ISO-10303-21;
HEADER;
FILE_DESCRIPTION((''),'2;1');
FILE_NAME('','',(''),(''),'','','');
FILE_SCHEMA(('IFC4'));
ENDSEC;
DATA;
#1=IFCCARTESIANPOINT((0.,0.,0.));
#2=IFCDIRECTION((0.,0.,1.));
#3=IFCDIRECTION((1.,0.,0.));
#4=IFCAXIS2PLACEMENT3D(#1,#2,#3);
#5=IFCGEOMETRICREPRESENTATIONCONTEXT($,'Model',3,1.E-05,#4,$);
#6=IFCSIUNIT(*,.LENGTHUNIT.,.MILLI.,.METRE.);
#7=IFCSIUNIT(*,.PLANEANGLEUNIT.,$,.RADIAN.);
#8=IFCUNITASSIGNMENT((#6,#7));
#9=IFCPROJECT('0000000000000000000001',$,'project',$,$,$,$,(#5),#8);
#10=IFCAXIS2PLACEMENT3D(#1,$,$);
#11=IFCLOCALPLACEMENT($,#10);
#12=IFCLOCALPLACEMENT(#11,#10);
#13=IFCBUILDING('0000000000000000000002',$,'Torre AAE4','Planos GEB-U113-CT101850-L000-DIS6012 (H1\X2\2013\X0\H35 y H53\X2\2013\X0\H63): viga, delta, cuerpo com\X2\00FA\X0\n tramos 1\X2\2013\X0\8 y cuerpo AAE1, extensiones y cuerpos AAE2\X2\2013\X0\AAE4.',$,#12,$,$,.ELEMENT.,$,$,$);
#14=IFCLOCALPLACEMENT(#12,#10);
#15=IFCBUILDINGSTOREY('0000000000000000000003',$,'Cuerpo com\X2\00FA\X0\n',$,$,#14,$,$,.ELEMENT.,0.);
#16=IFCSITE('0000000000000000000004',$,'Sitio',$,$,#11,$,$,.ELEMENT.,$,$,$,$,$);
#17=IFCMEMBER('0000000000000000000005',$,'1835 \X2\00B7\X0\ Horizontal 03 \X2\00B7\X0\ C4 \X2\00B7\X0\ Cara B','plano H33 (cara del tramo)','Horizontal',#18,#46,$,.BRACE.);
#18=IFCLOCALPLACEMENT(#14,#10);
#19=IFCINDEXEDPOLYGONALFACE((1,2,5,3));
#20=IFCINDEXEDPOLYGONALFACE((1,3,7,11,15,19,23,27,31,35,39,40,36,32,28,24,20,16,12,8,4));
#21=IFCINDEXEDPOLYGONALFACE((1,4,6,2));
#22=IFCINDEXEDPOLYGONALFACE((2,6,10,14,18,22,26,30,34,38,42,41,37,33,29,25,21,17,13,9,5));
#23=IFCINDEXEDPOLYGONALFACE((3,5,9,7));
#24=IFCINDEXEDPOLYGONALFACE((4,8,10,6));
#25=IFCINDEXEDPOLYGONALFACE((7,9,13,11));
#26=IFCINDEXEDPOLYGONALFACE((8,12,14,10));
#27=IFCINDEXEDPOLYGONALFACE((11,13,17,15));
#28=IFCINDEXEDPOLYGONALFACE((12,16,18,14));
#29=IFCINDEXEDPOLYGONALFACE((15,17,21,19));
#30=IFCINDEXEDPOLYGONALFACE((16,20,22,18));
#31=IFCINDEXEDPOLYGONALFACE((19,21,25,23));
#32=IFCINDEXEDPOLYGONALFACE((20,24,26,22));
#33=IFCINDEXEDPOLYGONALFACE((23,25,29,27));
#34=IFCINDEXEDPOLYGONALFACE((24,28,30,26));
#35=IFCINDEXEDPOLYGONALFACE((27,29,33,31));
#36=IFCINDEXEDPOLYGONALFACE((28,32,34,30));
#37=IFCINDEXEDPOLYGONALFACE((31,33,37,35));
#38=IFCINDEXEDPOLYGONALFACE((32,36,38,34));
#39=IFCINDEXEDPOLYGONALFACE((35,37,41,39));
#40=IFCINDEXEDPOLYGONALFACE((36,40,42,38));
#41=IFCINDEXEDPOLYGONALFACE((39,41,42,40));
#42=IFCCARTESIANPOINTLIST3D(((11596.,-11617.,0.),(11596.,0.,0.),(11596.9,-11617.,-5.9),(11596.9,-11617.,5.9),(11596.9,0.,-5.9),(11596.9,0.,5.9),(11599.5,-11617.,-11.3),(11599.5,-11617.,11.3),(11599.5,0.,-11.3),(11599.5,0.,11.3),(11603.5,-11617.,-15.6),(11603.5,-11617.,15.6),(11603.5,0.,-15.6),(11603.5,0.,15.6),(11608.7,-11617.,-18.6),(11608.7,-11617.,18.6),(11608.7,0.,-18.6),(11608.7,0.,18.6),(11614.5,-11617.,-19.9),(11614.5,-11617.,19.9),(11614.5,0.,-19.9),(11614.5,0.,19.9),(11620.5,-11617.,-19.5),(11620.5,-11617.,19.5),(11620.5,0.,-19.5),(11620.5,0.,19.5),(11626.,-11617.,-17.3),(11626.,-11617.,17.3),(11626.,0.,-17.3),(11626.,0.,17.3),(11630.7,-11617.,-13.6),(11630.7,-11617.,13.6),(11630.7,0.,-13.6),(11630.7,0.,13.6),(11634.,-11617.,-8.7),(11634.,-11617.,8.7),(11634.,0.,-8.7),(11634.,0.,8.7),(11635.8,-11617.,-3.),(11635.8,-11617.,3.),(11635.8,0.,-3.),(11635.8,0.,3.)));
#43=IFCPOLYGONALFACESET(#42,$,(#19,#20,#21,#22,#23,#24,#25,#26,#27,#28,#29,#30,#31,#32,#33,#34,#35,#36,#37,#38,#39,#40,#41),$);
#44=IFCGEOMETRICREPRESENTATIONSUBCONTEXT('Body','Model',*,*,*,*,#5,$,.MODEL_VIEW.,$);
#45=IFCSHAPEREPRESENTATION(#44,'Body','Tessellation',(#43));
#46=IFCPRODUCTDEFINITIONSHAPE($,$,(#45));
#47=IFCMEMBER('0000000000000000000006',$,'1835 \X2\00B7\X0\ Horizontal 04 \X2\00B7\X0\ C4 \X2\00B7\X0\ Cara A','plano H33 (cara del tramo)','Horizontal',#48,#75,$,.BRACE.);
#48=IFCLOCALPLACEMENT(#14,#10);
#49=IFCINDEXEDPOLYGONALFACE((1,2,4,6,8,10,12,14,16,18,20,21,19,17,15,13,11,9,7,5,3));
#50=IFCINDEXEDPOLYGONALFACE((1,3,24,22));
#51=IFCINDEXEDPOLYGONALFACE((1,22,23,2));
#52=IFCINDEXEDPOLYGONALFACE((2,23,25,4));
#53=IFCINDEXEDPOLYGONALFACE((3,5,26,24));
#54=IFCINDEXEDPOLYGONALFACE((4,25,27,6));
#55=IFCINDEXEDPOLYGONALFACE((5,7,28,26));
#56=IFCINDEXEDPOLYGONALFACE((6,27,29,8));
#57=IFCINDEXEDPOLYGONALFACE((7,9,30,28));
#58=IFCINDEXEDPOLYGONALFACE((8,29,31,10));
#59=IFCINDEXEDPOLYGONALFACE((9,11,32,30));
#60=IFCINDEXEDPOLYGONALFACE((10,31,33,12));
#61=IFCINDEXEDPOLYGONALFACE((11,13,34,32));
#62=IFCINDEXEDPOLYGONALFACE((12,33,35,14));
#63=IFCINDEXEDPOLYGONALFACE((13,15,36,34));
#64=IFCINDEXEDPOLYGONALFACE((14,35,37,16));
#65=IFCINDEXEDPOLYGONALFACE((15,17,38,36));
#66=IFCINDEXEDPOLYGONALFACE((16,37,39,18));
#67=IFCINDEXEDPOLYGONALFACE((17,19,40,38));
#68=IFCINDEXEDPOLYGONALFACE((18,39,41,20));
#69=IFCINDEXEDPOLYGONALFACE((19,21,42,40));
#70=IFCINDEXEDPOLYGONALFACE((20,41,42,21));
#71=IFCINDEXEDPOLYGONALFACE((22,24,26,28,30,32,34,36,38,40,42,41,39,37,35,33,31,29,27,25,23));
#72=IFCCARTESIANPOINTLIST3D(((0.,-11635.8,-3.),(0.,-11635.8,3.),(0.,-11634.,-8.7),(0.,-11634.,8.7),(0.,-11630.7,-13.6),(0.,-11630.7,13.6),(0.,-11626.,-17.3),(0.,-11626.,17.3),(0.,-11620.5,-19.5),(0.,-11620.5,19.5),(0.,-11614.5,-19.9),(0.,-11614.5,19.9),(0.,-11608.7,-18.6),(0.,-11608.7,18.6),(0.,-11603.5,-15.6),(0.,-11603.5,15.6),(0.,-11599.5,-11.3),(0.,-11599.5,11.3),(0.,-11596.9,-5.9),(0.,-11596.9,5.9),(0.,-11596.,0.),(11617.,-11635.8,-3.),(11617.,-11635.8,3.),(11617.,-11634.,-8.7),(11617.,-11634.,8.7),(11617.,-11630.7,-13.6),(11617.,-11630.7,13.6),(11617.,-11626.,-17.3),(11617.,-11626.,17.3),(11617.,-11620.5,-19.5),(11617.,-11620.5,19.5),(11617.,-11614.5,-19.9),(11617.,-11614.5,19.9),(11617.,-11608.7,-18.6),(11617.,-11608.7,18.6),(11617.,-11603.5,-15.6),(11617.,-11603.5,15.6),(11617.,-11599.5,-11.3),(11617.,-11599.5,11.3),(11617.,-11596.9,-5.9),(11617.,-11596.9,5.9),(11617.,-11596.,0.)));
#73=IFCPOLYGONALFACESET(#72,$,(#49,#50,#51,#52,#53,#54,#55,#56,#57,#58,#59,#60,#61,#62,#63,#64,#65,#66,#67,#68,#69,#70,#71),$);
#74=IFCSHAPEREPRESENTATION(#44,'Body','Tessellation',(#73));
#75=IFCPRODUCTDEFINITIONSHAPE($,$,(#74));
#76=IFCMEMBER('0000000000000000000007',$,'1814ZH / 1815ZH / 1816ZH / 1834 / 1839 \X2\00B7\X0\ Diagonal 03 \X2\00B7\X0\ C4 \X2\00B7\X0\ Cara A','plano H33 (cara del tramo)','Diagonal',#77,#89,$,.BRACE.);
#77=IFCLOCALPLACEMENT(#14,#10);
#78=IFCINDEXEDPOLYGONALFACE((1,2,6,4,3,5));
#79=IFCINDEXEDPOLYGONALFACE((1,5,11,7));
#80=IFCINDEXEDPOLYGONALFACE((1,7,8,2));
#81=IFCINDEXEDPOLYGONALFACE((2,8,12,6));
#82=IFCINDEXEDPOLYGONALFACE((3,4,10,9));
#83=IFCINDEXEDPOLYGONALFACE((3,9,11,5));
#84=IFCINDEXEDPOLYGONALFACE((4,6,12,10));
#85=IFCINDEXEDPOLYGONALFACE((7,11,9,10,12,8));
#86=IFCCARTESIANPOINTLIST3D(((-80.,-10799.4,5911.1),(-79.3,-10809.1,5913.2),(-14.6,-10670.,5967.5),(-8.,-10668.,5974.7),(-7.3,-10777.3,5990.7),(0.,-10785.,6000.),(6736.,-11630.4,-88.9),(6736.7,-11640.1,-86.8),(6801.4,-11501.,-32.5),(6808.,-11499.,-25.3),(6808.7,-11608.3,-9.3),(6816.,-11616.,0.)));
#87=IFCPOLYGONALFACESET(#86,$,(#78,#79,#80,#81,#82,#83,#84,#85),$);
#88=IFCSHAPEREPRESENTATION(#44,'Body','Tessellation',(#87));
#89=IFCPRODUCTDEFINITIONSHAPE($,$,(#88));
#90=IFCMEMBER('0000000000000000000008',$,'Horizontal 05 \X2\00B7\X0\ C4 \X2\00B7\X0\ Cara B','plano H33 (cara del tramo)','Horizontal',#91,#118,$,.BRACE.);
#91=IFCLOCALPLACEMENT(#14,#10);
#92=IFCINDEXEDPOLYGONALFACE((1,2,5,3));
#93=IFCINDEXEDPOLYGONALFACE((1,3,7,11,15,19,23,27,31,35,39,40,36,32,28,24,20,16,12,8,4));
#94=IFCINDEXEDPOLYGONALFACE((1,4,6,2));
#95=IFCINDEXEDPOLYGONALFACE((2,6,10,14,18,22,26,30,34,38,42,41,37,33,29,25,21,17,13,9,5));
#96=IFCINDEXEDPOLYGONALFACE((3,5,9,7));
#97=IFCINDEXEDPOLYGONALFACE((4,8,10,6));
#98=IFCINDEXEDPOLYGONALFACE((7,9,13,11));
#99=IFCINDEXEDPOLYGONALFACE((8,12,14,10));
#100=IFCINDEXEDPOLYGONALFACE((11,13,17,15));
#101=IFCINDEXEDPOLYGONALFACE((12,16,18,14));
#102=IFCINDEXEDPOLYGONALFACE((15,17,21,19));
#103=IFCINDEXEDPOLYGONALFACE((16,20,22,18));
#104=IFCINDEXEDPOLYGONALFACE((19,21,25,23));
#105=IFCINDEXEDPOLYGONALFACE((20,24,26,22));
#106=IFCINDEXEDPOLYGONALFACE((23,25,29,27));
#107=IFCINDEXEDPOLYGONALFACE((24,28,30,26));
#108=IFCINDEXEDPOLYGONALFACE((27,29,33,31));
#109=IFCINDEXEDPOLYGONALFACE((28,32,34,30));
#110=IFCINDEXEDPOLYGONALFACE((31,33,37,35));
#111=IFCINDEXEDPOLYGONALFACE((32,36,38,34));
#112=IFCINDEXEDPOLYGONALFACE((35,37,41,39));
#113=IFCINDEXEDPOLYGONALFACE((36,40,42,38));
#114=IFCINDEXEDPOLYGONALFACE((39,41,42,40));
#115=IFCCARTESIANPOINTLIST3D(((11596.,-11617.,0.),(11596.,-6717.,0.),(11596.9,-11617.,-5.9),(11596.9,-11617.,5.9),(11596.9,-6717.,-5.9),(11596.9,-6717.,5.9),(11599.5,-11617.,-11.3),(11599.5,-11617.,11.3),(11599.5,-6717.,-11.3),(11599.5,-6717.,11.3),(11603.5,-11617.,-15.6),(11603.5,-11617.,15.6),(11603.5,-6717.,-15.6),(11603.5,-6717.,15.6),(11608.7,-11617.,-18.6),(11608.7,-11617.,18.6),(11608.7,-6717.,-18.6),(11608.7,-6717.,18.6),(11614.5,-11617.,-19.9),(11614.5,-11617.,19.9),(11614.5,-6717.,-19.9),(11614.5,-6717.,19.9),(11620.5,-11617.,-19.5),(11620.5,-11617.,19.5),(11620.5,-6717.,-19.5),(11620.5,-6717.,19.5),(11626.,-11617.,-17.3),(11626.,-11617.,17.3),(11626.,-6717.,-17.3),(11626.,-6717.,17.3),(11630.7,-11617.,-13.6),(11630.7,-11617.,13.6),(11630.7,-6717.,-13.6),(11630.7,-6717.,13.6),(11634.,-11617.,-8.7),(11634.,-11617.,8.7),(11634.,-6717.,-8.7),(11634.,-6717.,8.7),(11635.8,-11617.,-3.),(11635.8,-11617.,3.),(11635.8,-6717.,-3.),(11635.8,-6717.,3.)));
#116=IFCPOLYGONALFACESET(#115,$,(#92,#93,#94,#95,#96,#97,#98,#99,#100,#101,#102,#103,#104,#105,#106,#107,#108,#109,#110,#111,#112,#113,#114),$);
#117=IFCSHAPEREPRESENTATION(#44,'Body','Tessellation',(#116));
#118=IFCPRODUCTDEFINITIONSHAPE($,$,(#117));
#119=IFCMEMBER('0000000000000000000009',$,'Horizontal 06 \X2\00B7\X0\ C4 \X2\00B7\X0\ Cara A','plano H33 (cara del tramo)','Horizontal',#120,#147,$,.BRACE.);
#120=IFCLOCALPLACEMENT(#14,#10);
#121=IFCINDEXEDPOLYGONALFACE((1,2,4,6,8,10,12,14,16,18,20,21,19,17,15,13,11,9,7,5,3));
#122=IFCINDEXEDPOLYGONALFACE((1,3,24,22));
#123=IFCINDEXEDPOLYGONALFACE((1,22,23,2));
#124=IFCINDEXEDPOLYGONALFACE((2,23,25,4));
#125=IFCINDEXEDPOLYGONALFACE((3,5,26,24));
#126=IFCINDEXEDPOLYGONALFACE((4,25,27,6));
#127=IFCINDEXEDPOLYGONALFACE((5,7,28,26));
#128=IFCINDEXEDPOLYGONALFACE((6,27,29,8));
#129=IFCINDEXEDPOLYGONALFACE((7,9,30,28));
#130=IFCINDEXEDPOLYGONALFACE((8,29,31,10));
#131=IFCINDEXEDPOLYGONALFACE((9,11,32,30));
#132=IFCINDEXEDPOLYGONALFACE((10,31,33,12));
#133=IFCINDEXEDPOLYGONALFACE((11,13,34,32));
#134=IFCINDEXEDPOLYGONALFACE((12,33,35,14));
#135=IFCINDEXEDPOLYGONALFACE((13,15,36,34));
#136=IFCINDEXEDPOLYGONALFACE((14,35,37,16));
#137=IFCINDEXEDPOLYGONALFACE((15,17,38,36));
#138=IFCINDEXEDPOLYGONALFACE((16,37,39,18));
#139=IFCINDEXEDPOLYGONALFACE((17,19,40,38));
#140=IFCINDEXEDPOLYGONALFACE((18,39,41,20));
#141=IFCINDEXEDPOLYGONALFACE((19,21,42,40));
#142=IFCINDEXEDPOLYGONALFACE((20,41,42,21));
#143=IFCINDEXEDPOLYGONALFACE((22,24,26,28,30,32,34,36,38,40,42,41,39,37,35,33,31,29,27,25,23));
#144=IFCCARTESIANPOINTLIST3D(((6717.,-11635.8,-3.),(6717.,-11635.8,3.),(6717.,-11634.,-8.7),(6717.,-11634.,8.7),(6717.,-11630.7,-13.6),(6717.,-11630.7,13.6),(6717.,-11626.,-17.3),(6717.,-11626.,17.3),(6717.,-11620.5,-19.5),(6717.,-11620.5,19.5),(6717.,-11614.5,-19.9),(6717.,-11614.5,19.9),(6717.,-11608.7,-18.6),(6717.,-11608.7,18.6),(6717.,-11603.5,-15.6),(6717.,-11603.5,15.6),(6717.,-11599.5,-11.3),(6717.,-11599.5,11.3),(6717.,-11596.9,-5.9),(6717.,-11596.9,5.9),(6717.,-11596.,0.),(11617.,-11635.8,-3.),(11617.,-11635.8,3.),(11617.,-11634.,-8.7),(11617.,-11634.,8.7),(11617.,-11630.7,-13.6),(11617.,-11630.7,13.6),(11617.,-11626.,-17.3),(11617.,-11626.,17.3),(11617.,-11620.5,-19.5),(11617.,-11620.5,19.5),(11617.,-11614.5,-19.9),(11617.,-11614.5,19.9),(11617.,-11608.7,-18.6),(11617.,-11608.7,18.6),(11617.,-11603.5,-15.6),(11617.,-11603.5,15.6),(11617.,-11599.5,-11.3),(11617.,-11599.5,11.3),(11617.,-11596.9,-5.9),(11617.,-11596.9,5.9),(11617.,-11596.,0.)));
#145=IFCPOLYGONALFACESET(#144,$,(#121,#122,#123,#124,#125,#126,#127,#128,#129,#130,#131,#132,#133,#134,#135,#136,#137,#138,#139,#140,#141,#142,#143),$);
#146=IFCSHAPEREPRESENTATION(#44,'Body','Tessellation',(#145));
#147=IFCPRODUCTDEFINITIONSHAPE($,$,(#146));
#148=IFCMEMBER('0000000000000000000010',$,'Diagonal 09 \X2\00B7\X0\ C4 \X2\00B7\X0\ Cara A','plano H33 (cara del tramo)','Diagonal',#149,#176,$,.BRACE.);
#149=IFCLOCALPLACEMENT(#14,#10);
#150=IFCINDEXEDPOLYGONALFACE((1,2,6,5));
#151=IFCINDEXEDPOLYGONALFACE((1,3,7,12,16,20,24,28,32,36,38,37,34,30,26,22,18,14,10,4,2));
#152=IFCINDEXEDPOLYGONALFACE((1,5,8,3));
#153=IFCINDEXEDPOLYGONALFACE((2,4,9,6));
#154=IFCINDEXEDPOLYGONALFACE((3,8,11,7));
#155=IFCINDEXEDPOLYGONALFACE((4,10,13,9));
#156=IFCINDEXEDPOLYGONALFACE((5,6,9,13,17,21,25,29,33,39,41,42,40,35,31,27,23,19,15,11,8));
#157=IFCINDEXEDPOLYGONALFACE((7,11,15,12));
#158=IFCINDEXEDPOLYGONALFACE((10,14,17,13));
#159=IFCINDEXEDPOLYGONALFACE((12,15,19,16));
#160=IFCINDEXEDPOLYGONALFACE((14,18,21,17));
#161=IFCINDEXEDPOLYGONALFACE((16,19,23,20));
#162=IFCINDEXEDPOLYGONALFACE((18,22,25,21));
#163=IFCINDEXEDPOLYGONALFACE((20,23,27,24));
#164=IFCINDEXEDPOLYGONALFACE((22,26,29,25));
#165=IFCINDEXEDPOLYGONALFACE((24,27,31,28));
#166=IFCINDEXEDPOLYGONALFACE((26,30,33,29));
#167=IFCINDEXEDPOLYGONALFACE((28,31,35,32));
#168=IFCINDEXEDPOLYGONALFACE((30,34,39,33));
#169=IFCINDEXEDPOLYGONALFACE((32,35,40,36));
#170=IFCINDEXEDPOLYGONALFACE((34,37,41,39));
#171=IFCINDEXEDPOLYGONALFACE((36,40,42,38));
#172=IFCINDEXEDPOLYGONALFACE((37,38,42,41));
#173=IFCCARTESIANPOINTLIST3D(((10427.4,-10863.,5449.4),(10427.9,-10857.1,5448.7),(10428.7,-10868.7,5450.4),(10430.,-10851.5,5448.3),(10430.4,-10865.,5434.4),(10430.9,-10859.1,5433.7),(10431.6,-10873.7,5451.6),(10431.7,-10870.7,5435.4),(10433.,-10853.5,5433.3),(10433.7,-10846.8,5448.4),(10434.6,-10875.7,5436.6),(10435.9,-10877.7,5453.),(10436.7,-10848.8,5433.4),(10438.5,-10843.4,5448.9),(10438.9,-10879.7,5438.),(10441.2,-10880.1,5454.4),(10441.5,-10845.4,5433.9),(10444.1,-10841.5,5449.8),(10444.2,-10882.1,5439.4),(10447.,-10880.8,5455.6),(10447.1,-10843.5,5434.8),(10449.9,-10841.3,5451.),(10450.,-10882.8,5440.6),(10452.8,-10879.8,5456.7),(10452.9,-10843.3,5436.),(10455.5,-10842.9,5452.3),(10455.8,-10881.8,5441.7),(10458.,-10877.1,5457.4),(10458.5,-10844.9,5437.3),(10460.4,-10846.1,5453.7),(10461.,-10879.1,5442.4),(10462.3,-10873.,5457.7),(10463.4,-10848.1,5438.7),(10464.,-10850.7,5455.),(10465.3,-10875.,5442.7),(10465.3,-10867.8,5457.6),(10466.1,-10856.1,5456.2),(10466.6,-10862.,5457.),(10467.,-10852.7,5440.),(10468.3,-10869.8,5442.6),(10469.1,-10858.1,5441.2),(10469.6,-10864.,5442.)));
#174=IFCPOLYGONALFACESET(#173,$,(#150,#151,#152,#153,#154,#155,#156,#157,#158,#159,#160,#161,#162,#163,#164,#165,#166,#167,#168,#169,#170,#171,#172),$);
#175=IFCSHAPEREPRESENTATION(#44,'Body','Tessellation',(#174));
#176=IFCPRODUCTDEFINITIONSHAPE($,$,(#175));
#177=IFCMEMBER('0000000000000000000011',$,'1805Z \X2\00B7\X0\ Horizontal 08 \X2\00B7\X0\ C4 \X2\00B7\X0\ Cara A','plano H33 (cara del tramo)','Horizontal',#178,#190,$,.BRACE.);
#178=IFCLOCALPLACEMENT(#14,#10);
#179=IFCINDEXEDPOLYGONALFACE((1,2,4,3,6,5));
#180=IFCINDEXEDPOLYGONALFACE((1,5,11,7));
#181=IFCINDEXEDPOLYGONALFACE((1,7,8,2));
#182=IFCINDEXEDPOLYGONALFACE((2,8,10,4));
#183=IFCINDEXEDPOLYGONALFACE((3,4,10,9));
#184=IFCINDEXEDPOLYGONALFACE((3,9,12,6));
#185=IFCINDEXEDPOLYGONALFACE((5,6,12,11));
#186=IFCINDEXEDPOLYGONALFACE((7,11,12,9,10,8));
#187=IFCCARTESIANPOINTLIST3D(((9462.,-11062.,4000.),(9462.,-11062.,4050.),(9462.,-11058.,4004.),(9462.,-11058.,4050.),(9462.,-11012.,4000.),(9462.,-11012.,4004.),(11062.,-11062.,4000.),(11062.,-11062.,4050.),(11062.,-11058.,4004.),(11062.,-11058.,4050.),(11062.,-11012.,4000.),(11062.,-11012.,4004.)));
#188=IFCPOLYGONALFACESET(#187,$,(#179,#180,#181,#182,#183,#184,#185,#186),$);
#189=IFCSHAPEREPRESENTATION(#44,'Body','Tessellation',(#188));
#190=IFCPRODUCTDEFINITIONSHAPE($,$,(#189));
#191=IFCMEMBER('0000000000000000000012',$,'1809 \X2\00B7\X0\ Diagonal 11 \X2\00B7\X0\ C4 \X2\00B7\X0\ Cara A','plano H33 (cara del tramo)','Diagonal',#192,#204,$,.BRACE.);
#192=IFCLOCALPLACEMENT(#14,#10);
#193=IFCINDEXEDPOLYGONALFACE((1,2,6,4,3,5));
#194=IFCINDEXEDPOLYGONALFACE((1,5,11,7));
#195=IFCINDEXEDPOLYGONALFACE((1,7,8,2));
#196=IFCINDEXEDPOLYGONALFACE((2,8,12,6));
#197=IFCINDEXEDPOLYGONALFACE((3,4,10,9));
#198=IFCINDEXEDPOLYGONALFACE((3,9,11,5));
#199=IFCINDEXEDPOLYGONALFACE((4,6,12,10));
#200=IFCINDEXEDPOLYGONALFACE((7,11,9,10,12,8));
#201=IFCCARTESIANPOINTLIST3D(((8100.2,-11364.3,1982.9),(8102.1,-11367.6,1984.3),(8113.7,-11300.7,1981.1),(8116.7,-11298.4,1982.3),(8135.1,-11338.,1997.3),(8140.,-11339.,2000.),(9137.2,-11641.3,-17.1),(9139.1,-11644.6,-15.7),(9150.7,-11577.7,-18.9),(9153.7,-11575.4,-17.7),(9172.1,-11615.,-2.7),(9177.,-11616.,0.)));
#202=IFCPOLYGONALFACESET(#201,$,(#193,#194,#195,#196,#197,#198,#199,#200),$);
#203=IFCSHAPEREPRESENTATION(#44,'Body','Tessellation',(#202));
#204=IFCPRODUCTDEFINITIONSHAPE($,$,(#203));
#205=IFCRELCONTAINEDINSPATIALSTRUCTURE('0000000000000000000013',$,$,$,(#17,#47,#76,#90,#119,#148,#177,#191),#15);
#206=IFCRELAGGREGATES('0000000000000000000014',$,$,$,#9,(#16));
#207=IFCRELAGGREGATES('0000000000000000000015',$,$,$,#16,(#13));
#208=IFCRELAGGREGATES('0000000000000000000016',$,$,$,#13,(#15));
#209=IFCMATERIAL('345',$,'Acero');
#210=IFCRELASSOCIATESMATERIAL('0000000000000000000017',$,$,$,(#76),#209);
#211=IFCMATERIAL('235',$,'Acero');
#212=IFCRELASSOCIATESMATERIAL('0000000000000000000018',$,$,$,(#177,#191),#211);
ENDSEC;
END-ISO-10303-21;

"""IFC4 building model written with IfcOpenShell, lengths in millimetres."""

from ifc_helpers import new_model, si_unit, frame, frame_2d, origin, origin_with_axes, place, context, subcontext, project, spatial, circle, l_section, extrude, material, element, save


model = new_model("IFC4")

# Units and contexts
model_context = context("Model", 3, precision=1e-05, world=origin_with_axes())
body_context = subcontext(model_context, "Body", "Model", "MODEL_VIEW")
ifc_project = project(units=[si_unit("LENGTHUNIT", "METRE", prefix="MILLI"), si_unit("PLANEANGLEUNIT", "RADIAN")], contexts=[model_context])

# Site, building, storey
site_placement = place(None, origin())
site = spatial("IfcSite", under=ifc_project, at=site_placement, Name="Sitio", CompositionType="ELEMENT")
building_placement = place(site_placement, origin())
building = spatial("IfcBuilding", under=site, at=building_placement, Name="Torre AAE4", Description="Planos GEB-U113-CT101850-L000-DIS6012 (H1–H35 y H53–H63): viga, delta, cuerpo común tramos 1–8 y cuerpo AAE1, extensiones y cuerpos AAE2–AAE4.", CompositionType="ELEMENT")
storey_placement = place(building_placement, origin())
storey = spatial("IfcBuildingStorey", under=building, at=storey_placement, Name="Cuerpo común", CompositionType="ELEMENT", Elevation=0.0)

# Members
for number, where, z_axis, x_axis, name in (
    (1, (11616.0, -11617.0, 0.0), (0.0, 1.0, 0.0), (-1.0, 0.0, 0.0), "1835 · Horizontal 03 · C4 · Cara B"),
    (2, (11617.0, -11616.0, 0.0), (-1.0, 0.0, 0.0), (0.0, 1.0, 0.0), "1835 · Horizontal 04 · C4 · Cara A"),
):
    element("IfcMember", number, at=place(storey_placement, frame(where, z_axis=z_axis, x_axis=x_axis)), inside=storey, Name=name, Description="plano H33 (cara del tramo)", ObjectType="Horizontal", PredefinedType="BRACE", context=body_context, shape_type="SweptSolid", body=[
        extrude(circle(Radius=20.0), None, (0.0, 0.0, 1.0), 11617.0),
    ])
ifc_material_1 = material(Name="345", Category="Acero")
member_1_placement = place(storey_placement, frame((6816.0, -11616.0, 0.0), z_axis=(-0.747485, 0.091133, 0.657998), x_axis=(-0.066441, 0.975321, -0.210559)))
element("IfcMember", 3, at=member_1_placement, inside=storey, material=ifc_material_1, Name="1814ZH / 1815ZH / 1816ZH / 1834 / 1839 · Diagonal 03 · C4 · Cara A", Description="plano H33 (cara del tramo)", ObjectType="Diagonal", PredefinedType="BRACE", context=body_context, shape_type="SweptSolid", body=[
    extrude(l_section(Depth=120.0, Width=120.0, Thickness=10.0, at=frame_2d((60.0, 60.0))), None, (0.0, 0.0, 1.0), 9118.6),
])
for number, where, z_axis, x_axis, name in (
    (4, (11616.0, -11617.0, 0.0), (0.0, 1.0, 0.0), (-1.0, 0.0, 0.0), "Horizontal 05 · C4 · Cara B"),
    (5, (11617.0, -11616.0, 0.0), (-1.0, 0.0, 0.0), (0.0, 1.0, 0.0), "Horizontal 06 · C4 · Cara A"),
):
    element("IfcMember", number, at=place(storey_placement, frame(where, z_axis=z_axis, x_axis=x_axis)), inside=storey, Name=name, Description="plano H33 (cara del tramo)", ObjectType="Horizontal", PredefinedType="BRACE", context=body_context, shape_type="SweptSolid", body=[
        extrude(circle(Radius=20.0), None, (0.0, 0.0, 1.0), 4900.0),
    ])
member_2_placement = place(storey_placement, frame((10447.0, -10861.0, 5453.0), z_axis=(0.194461, -0.129641, -0.972306), x_axis=(-0.666463, 0.709839, -0.227938)))
element("IfcMember", 6, at=member_2_placement, inside=storey, Name="Diagonal 09 · C4 · Cara A", Description="plano H33 (cara del tramo)", ObjectType="Diagonal", PredefinedType="BRACE", context=body_context, shape_type="SweptSolid", body=[
    extrude(circle(Radius=20.0), None, (0.0, 0.0, 1.0), 15.4),
])
ifc_material_2 = material(Name="235", Category="Acero")
member_3_placement = place(storey_placement, frame((9462.0, -11062.0, 4000.0), z_axis=(1.0, 0.0, 0.0), x_axis=(0.0, 1.0, 0.0)))
element("IfcMember", 7, at=member_3_placement, inside=storey, material=ifc_material_2, Name="1805Z · Horizontal 08 · C4 · Cara A", Description="plano H33 (cara del tramo)", ObjectType="Horizontal", PredefinedType="BRACE", context=body_context, shape_type="SweptSolid", body=[
    extrude(l_section(Depth=50.0, Width=50.0, Thickness=4.0, at=frame_2d((25.0, 25.0))), None, (0.0, 0.0, 1.0), 1600.0),
])
member_4_placement = place(storey_placement, frame((9177.0, -11616.0, 0.0), z_axis=(-0.456864, 0.122036, 0.881126), x_axis=(-0.465545, 0.811254, -0.353744)))
element("IfcMember", 8, at=member_4_placement, inside=storey, material=ifc_material_2, Name="1809 · Diagonal 11 · C4 · Cara A", Description="plano H33 (cara del tramo)", ObjectType="Diagonal", PredefinedType="BRACE", context=body_context, shape_type="SweptSolid", body=[
    extrude(l_section(Depth=50.0, Width=50.0, Thickness=4.0, at=frame_2d((25.0, 25.0))), None, (0.0, 0.0, 1.0), 2269.8),
])

save(model, "model.ifc")
